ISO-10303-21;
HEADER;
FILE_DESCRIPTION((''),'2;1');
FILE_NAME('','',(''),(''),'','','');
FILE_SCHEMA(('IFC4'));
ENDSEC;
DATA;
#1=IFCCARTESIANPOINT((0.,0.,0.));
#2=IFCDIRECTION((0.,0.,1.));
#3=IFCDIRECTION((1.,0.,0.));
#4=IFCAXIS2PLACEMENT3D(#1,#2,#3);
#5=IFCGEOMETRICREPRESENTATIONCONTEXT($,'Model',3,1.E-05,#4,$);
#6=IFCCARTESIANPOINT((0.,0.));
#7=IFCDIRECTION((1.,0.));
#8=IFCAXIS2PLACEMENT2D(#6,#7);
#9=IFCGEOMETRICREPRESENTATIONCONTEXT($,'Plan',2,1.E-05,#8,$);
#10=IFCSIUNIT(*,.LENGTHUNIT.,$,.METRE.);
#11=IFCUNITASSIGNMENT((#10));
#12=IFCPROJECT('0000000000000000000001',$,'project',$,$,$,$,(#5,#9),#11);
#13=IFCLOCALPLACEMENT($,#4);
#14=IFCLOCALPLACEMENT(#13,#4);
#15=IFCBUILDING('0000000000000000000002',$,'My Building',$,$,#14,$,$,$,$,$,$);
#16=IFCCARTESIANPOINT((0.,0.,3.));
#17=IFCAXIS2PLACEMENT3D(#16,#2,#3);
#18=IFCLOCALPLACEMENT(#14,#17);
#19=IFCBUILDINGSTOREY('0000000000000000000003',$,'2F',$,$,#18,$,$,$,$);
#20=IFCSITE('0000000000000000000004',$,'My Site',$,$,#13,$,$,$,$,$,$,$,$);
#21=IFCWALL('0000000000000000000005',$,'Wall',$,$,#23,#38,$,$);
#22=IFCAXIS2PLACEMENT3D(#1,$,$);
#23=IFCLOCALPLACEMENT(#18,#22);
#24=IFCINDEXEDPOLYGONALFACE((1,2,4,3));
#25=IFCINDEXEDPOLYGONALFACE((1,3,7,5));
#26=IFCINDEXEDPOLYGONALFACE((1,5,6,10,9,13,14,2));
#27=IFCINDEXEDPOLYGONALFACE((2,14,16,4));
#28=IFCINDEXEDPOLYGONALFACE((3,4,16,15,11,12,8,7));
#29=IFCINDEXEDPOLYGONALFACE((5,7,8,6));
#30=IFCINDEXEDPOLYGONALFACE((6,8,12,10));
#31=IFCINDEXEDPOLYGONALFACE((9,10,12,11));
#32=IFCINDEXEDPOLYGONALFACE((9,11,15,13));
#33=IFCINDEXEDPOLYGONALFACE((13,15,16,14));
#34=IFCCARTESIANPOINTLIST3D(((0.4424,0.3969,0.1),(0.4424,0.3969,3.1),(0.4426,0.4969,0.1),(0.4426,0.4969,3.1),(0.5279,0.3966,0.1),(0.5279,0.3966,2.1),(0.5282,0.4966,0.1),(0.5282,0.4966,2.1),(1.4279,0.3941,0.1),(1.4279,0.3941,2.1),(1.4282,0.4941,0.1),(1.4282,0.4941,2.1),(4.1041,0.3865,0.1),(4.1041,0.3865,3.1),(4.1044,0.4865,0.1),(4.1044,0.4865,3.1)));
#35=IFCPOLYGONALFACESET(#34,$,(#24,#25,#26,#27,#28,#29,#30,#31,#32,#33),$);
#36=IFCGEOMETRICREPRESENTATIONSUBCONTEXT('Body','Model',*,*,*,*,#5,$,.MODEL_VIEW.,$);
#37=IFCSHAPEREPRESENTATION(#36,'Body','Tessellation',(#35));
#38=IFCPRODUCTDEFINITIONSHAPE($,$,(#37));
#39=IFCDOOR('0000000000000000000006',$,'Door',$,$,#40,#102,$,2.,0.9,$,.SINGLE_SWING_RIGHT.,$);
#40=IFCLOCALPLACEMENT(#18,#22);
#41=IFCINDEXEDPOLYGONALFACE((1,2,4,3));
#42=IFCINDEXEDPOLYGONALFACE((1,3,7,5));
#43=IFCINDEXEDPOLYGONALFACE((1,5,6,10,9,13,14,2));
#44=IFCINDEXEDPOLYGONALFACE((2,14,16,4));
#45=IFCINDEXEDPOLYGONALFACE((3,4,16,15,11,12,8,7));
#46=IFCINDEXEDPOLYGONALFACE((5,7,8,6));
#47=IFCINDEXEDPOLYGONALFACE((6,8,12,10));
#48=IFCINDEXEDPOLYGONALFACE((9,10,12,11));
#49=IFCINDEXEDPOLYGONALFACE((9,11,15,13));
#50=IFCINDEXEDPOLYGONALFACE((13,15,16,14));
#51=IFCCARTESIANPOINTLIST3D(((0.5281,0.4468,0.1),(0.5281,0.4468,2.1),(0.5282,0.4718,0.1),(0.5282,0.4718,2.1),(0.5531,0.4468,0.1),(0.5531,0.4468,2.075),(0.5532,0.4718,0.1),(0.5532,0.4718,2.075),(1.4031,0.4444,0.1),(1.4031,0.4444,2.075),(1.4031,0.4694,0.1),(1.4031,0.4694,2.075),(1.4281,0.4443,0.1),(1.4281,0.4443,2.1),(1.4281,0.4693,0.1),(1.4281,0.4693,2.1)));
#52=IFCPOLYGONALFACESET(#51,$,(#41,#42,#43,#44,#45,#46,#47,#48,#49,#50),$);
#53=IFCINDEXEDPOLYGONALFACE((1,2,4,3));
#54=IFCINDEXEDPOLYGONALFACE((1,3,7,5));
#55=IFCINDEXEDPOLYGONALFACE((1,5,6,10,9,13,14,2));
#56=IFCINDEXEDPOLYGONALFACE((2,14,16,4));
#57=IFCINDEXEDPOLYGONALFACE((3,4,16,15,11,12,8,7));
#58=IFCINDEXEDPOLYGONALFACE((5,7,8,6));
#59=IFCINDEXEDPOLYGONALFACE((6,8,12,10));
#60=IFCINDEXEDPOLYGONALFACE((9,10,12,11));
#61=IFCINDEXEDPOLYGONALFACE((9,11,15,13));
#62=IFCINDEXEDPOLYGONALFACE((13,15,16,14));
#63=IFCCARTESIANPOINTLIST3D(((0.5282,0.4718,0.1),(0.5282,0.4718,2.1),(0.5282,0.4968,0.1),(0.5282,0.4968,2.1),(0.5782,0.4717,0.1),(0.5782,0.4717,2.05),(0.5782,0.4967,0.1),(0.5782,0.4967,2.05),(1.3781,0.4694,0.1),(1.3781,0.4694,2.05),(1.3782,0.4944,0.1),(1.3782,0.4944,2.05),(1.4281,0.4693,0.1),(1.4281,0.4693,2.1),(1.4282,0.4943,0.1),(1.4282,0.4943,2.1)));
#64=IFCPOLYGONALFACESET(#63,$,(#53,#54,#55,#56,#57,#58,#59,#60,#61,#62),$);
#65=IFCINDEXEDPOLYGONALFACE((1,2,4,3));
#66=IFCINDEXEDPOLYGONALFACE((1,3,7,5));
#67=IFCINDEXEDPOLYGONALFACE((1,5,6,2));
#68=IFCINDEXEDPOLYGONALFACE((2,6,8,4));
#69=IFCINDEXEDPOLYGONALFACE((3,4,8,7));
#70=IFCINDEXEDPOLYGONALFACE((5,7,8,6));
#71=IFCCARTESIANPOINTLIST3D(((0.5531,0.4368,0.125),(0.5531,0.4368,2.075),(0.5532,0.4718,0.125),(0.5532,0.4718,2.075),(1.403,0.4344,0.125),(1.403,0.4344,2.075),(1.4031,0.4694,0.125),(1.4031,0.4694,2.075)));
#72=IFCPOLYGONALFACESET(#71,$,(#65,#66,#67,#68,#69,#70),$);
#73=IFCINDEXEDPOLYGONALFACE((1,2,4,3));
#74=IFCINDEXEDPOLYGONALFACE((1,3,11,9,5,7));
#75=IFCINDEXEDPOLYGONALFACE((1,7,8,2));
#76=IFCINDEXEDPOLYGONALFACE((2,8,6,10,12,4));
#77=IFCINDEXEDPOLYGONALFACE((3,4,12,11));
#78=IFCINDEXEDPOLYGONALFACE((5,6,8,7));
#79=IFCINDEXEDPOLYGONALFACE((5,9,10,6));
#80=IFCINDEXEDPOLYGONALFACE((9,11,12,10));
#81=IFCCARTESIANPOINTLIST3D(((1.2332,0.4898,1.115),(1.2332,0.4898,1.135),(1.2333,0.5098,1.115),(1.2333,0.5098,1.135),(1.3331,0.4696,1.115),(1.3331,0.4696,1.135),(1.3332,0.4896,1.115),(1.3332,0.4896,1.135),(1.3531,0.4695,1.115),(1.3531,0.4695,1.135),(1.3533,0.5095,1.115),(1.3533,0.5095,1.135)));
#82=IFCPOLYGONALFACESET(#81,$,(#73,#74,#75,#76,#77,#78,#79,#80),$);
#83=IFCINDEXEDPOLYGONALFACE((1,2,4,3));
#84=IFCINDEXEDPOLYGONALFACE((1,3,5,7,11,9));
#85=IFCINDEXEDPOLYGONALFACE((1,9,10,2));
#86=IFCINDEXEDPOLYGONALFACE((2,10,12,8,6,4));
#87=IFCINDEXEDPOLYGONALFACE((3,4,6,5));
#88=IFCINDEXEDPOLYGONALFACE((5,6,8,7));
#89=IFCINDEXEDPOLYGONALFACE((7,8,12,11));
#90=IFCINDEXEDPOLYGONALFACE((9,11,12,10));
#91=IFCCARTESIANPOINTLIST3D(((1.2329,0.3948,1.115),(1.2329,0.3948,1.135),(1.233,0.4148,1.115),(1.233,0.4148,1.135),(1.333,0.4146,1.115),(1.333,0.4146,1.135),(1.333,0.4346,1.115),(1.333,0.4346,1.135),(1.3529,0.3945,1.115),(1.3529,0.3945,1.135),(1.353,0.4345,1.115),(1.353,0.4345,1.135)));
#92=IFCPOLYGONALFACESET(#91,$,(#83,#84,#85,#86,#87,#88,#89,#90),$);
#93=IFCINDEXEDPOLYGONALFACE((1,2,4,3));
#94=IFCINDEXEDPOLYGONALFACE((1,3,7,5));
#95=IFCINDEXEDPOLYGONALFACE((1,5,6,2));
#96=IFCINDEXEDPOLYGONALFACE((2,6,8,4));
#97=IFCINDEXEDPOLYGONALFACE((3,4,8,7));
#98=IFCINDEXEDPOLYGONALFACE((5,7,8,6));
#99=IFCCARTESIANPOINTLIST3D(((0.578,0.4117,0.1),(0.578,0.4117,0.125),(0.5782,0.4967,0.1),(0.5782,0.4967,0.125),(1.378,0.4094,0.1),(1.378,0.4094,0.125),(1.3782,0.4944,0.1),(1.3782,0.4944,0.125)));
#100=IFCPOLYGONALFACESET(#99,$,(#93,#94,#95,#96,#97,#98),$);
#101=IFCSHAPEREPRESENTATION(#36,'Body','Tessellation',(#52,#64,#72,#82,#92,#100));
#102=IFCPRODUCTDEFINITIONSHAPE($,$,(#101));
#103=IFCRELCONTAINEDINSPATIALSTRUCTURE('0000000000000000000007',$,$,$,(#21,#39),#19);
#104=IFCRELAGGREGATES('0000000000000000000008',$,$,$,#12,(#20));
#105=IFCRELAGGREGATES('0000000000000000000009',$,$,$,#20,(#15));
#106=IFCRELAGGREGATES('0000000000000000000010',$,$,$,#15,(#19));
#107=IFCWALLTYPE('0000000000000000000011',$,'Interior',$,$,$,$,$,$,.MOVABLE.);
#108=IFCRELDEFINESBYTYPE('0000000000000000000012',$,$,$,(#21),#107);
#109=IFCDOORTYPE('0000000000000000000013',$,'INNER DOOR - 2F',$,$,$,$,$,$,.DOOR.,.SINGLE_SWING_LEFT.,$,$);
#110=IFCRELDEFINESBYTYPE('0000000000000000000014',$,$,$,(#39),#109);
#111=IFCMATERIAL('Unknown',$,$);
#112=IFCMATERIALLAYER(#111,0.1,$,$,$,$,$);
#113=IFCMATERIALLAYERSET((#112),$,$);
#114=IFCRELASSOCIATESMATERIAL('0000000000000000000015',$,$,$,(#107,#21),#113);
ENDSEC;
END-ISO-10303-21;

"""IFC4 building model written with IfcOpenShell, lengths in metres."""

from ifc_helpers import new_model, entity, si_unit, frame, origin_with_axes, origin_2d_with_axis, place, context, subcontext, project, spatial, line, indexed_curve, outline, extrude, shape, source, transform, mapped, material, layer, layer_set, layer_usage, type_object, type_shapes, element, fill, save


model = new_model("IFC4")

# Units and contexts
model_context = context("Model", 3, precision=1e-05, world=origin_with_axes())
plan_context = context("Plan", 2, precision=1e-05, world=origin_2d_with_axis())
body_context_1 = subcontext(model_context, "Body", "Model", "MODEL_VIEW")
body_context_2 = subcontext(plan_context, "Body", "Plan", "PLAN_VIEW")
ifc_project = project(units=[si_unit("LENGTHUNIT", "METRE")], contexts=[model_context, plan_context])

# Site, building, storey
site_placement = place(None, origin_with_axes())
site = spatial("IfcSite", under=ifc_project, at=site_placement, Name="My Site")
building_placement = place(site_placement, origin_with_axes())
building = spatial("IfcBuilding", under=site, at=building_placement, Name="My Building")
storey_placement = place(building_placement, frame((0.0, 0.0, 3.0), z_axis=(0.0, 0.0, 1.0), x_axis=(1.0, 0.0, 0.0)))
storey = spatial("IfcBuildingStorey", under=building, at=storey_placement, Name="2F")

# Shared definitions
ifc_material = material(Name="Unknown")

# Wall, opening, door
ifc_layer_1 = layer(ifc_material, 0.1)
ifc_layer_set_1 = layer_set([ifc_layer_1])
ifc_layer_usage_1 = layer_usage(ifc_layer_set_1, "AXIS2", "POSITIVE", 0.0)
wall_type_1 = type_object("IfcWallType", Name="Interior", PredefinedType="MOVABLE", material=ifc_layer_set_1)
wall_1_placement = place(storey_placement, frame((0.4424, 0.3969, 0.1), z_axis=(0.0, 0.0, 1.0), x_axis=(0.999996, -0.002846, 0.0)))
wall_1 = element("IfcWall", 1, at=wall_1_placement, inside=storey, type_object=wall_type_1, material=ifc_layer_usage_1, Name="Wall", context=body_context_1, shape_type="SweptSolid", body=[
    extrude(outline(indexed_curve([(0.0, 0.0), (0.0, 0.1), (3.6618, 0.1), (3.6618, 0.0)], segments=[line(1, 2, 3, 4, 1)])), origin_with_axes(), (0.0, 0.0, 1.0), 3.0),
])
shared_shape_1 = source(origin_with_axes(), body_context_1, "Body", "SweptSolid", [
    extrude(outline(indexed_curve([(0.0, 0.0), (0.9, 0.0), (0.9, 2.0), (0.0, 2.0)], segments=[line(1, 2, 3, 4, 1)])), frame((0.0, -0.6, 0.0), z_axis=(0.0, -1.0, 0.0), x_axis=(1.0, 0.0, 0.0)), (0.0, 0.0, -1.0), 1.2),
])
opening_1_placement = place(wall_1_placement, frame((0.9856, 0.1002, 0.0), z_axis=(0.0, 0.0, 1.0), x_axis=(-1.0, 0.0, 0.0)))
opening_1 = element("IfcOpeningElement", 2, at=opening_1_placement, cuts=wall_1, PredefinedType="OPENING", context=body_context_1, shape_type="MappedRepresentation", body=[
    mapped(shared_shape_1, transform((0.0, 0.0, 0.0), x_axis=(1.0, 0.0, 0.0), y_axis=(0.0, 1.0, 0.0), z_axis=(0.0, 0.0, 1.0), scale=1.0)),
])
door_type_1 = type_object("IfcDoorType", Name="INNER DOOR - 2F", OperationType="SINGLE_SWING_LEFT", PredefinedType="DOOR")
shared_shape_2 = source(origin_with_axes(), body_context_1, "Body", "SweptSolid", [
    extrude(outline(indexed_curve([(0.0, 0.0), (0.0, 2.0), (0.9, 2.0), (0.9, 0.0), (0.875, 0.0), (0.875, 1.975), (0.025, 1.975), (0.025, 0.0)], segments=[line(1, 2, 3, 4, 5, 6, 7, 8, 1)])), frame((0.0, 0.025, 0.0), z_axis=(0.0, -1.0, 0.0), x_axis=(1.0, 0.0, 0.0)), (0.0, 0.0, -1.0), 0.025),
    extrude(outline(indexed_curve([(0.0, 0.0), (0.0, 2.0), (0.9, 2.0), (0.9, 0.0), (0.85, 0.0), (0.85, 1.95), (0.05, 1.95), (0.05, 0.0)], segments=[line(1, 2, 3, 4, 5, 6, 7, 8, 1)])), frame((0.0, 0.0, 0.0), z_axis=(0.0, -1.0, 0.0), x_axis=(1.0, 0.0, 0.0)), (0.0, 0.0, -1.0), 0.025),
    extrude(outline(indexed_curve([(0.0, 0.0), (0.85, 0.0), (0.85, 0.035), (0.0, 0.035)], segments=[line(1, 2, 3, 4, 1)])), frame((0.025, 0.025, 0.025), z_axis=(0.0, 0.0, 1.0), x_axis=(1.0, 0.0, 0.0)), (0.0, 0.0, 1.0), 1.95),
    extrude(outline(indexed_curve([(0.0, 0.0), (0.0, -0.04), (0.12, -0.04), (0.12, -0.02), (0.02, -0.02), (0.02, 0.0)], segments=[line(1, 2, 3, 4, 5, 6, 1)])), frame((0.075, 0.025, 1.015), z_axis=(0.0, 0.0, 1.0), x_axis=(1.0, 0.0, 0.0)), (0.0, 0.0, 1.0), 0.02),
    extrude(outline(indexed_curve([(0.0, 0.0), (0.0, 0.04), (0.12, 0.04), (0.12, 0.02), (0.02, 0.02), (0.02, 0.0)], segments=[line(1, 2, 3, 4, 5, 6, 1)])), frame((0.075, 0.06, 1.015), z_axis=(0.0, 0.0, 1.0), x_axis=(1.0, 0.0, 0.0)), (0.0, 0.0, 1.0), 0.02),
    extrude(outline(indexed_curve([(0.0, 0.0), (0.8, 0.0), (0.8, 0.085), (0.0, 0.085)], segments=[line(1, 2, 3, 4, 1)])), frame((0.05, 0.0, 0.0), z_axis=(0.0, 0.0, 1.0), x_axis=(1.0, 0.0, 0.0)), (0.0, 0.0, 1.0), 0.025),
])
shared_shape_3 = source(origin_with_axes(), body_context_2, "Body", "Curve2D", [
    entity("IfcIndexedPolyCurve", entity("IfcCartesianPointList2D", [[0.0, 0.0], [0.0, 0.05], [0.025, 0.05], [0.025, 0.025], [0.05, 0.025], [0.05, 0.0]]), [entity("IfcLineIndex", [1, 2, 3, 4, 5, 6, 1])]),
    entity("IfcIndexedPolyCurve", entity("IfcCartesianPointList2D", [[0.9, 0.0], [0.9, 0.05], [0.875, 0.05], [0.875, 0.025], [0.85, 0.025], [0.85, 0.0]]), [entity("IfcLineIndex", [1, 2, 3, 4, 5, 6, 1])]),
    entity("IfcTrimmedCurve", entity("IfcEllipse", entity("IfcAxis2Placement2D", entity("IfcCartesianPoint", [0.84, 0.05]), entity("IfcDirection", [1.0, 0.0])), 0.815, 0.85), [entity("IfcCartesianPoint", [0.84, 0.9])], [entity("IfcCartesianPoint", [0.025, 0.05])], True, "CARTESIAN"),
    entity("IfcIndexedPolyCurve", entity("IfcCartesianPointList2D", [[0.875, 0.05], [0.84, 0.05], [0.84, 0.9], [0.875, 0.9]]), [entity("IfcLineIndex", [1, 2, 3, 4, 1])]),
])
type_shapes(door_type_1, [shared_shape_2, shared_shape_3])
door_1_placement = place(opening_1_placement, frame((0.0, 0.0, 0.0), z_axis=(0.0, 0.0, 1.0), x_axis=(1.0, 0.0, 0.0)))
door_1 = element("IfcDoor", 3, at=door_1_placement, inside=storey, type_object=door_type_1, Name="Door", OperationType="SINGLE_SWING_RIGHT", OverallHeight=2.0, OverallWidth=0.9, shapes=[
    shape(body_context_1, "Body", "MappedRepresentation", [mapped(shared_shape_2, transform((0.0, 0.0, 0.0), x_axis=(1.0, 0.0, 0.0), y_axis=(0.0, 1.0, 0.0), z_axis=(0.0, 0.0, 1.0), scale=1.0))]),
    shape(body_context_2, "Body", "MappedRepresentation", [mapped(shared_shape_3, transform((0.0, 0.0, 0.0), x_axis=(1.0, 0.0, 0.0), y_axis=(0.0, 1.0, 0.0), z_axis=(0.0, 0.0, 1.0), scale=1.0))]),
])
fill(opening_1, door_1)

save(model, "model.ifc")
